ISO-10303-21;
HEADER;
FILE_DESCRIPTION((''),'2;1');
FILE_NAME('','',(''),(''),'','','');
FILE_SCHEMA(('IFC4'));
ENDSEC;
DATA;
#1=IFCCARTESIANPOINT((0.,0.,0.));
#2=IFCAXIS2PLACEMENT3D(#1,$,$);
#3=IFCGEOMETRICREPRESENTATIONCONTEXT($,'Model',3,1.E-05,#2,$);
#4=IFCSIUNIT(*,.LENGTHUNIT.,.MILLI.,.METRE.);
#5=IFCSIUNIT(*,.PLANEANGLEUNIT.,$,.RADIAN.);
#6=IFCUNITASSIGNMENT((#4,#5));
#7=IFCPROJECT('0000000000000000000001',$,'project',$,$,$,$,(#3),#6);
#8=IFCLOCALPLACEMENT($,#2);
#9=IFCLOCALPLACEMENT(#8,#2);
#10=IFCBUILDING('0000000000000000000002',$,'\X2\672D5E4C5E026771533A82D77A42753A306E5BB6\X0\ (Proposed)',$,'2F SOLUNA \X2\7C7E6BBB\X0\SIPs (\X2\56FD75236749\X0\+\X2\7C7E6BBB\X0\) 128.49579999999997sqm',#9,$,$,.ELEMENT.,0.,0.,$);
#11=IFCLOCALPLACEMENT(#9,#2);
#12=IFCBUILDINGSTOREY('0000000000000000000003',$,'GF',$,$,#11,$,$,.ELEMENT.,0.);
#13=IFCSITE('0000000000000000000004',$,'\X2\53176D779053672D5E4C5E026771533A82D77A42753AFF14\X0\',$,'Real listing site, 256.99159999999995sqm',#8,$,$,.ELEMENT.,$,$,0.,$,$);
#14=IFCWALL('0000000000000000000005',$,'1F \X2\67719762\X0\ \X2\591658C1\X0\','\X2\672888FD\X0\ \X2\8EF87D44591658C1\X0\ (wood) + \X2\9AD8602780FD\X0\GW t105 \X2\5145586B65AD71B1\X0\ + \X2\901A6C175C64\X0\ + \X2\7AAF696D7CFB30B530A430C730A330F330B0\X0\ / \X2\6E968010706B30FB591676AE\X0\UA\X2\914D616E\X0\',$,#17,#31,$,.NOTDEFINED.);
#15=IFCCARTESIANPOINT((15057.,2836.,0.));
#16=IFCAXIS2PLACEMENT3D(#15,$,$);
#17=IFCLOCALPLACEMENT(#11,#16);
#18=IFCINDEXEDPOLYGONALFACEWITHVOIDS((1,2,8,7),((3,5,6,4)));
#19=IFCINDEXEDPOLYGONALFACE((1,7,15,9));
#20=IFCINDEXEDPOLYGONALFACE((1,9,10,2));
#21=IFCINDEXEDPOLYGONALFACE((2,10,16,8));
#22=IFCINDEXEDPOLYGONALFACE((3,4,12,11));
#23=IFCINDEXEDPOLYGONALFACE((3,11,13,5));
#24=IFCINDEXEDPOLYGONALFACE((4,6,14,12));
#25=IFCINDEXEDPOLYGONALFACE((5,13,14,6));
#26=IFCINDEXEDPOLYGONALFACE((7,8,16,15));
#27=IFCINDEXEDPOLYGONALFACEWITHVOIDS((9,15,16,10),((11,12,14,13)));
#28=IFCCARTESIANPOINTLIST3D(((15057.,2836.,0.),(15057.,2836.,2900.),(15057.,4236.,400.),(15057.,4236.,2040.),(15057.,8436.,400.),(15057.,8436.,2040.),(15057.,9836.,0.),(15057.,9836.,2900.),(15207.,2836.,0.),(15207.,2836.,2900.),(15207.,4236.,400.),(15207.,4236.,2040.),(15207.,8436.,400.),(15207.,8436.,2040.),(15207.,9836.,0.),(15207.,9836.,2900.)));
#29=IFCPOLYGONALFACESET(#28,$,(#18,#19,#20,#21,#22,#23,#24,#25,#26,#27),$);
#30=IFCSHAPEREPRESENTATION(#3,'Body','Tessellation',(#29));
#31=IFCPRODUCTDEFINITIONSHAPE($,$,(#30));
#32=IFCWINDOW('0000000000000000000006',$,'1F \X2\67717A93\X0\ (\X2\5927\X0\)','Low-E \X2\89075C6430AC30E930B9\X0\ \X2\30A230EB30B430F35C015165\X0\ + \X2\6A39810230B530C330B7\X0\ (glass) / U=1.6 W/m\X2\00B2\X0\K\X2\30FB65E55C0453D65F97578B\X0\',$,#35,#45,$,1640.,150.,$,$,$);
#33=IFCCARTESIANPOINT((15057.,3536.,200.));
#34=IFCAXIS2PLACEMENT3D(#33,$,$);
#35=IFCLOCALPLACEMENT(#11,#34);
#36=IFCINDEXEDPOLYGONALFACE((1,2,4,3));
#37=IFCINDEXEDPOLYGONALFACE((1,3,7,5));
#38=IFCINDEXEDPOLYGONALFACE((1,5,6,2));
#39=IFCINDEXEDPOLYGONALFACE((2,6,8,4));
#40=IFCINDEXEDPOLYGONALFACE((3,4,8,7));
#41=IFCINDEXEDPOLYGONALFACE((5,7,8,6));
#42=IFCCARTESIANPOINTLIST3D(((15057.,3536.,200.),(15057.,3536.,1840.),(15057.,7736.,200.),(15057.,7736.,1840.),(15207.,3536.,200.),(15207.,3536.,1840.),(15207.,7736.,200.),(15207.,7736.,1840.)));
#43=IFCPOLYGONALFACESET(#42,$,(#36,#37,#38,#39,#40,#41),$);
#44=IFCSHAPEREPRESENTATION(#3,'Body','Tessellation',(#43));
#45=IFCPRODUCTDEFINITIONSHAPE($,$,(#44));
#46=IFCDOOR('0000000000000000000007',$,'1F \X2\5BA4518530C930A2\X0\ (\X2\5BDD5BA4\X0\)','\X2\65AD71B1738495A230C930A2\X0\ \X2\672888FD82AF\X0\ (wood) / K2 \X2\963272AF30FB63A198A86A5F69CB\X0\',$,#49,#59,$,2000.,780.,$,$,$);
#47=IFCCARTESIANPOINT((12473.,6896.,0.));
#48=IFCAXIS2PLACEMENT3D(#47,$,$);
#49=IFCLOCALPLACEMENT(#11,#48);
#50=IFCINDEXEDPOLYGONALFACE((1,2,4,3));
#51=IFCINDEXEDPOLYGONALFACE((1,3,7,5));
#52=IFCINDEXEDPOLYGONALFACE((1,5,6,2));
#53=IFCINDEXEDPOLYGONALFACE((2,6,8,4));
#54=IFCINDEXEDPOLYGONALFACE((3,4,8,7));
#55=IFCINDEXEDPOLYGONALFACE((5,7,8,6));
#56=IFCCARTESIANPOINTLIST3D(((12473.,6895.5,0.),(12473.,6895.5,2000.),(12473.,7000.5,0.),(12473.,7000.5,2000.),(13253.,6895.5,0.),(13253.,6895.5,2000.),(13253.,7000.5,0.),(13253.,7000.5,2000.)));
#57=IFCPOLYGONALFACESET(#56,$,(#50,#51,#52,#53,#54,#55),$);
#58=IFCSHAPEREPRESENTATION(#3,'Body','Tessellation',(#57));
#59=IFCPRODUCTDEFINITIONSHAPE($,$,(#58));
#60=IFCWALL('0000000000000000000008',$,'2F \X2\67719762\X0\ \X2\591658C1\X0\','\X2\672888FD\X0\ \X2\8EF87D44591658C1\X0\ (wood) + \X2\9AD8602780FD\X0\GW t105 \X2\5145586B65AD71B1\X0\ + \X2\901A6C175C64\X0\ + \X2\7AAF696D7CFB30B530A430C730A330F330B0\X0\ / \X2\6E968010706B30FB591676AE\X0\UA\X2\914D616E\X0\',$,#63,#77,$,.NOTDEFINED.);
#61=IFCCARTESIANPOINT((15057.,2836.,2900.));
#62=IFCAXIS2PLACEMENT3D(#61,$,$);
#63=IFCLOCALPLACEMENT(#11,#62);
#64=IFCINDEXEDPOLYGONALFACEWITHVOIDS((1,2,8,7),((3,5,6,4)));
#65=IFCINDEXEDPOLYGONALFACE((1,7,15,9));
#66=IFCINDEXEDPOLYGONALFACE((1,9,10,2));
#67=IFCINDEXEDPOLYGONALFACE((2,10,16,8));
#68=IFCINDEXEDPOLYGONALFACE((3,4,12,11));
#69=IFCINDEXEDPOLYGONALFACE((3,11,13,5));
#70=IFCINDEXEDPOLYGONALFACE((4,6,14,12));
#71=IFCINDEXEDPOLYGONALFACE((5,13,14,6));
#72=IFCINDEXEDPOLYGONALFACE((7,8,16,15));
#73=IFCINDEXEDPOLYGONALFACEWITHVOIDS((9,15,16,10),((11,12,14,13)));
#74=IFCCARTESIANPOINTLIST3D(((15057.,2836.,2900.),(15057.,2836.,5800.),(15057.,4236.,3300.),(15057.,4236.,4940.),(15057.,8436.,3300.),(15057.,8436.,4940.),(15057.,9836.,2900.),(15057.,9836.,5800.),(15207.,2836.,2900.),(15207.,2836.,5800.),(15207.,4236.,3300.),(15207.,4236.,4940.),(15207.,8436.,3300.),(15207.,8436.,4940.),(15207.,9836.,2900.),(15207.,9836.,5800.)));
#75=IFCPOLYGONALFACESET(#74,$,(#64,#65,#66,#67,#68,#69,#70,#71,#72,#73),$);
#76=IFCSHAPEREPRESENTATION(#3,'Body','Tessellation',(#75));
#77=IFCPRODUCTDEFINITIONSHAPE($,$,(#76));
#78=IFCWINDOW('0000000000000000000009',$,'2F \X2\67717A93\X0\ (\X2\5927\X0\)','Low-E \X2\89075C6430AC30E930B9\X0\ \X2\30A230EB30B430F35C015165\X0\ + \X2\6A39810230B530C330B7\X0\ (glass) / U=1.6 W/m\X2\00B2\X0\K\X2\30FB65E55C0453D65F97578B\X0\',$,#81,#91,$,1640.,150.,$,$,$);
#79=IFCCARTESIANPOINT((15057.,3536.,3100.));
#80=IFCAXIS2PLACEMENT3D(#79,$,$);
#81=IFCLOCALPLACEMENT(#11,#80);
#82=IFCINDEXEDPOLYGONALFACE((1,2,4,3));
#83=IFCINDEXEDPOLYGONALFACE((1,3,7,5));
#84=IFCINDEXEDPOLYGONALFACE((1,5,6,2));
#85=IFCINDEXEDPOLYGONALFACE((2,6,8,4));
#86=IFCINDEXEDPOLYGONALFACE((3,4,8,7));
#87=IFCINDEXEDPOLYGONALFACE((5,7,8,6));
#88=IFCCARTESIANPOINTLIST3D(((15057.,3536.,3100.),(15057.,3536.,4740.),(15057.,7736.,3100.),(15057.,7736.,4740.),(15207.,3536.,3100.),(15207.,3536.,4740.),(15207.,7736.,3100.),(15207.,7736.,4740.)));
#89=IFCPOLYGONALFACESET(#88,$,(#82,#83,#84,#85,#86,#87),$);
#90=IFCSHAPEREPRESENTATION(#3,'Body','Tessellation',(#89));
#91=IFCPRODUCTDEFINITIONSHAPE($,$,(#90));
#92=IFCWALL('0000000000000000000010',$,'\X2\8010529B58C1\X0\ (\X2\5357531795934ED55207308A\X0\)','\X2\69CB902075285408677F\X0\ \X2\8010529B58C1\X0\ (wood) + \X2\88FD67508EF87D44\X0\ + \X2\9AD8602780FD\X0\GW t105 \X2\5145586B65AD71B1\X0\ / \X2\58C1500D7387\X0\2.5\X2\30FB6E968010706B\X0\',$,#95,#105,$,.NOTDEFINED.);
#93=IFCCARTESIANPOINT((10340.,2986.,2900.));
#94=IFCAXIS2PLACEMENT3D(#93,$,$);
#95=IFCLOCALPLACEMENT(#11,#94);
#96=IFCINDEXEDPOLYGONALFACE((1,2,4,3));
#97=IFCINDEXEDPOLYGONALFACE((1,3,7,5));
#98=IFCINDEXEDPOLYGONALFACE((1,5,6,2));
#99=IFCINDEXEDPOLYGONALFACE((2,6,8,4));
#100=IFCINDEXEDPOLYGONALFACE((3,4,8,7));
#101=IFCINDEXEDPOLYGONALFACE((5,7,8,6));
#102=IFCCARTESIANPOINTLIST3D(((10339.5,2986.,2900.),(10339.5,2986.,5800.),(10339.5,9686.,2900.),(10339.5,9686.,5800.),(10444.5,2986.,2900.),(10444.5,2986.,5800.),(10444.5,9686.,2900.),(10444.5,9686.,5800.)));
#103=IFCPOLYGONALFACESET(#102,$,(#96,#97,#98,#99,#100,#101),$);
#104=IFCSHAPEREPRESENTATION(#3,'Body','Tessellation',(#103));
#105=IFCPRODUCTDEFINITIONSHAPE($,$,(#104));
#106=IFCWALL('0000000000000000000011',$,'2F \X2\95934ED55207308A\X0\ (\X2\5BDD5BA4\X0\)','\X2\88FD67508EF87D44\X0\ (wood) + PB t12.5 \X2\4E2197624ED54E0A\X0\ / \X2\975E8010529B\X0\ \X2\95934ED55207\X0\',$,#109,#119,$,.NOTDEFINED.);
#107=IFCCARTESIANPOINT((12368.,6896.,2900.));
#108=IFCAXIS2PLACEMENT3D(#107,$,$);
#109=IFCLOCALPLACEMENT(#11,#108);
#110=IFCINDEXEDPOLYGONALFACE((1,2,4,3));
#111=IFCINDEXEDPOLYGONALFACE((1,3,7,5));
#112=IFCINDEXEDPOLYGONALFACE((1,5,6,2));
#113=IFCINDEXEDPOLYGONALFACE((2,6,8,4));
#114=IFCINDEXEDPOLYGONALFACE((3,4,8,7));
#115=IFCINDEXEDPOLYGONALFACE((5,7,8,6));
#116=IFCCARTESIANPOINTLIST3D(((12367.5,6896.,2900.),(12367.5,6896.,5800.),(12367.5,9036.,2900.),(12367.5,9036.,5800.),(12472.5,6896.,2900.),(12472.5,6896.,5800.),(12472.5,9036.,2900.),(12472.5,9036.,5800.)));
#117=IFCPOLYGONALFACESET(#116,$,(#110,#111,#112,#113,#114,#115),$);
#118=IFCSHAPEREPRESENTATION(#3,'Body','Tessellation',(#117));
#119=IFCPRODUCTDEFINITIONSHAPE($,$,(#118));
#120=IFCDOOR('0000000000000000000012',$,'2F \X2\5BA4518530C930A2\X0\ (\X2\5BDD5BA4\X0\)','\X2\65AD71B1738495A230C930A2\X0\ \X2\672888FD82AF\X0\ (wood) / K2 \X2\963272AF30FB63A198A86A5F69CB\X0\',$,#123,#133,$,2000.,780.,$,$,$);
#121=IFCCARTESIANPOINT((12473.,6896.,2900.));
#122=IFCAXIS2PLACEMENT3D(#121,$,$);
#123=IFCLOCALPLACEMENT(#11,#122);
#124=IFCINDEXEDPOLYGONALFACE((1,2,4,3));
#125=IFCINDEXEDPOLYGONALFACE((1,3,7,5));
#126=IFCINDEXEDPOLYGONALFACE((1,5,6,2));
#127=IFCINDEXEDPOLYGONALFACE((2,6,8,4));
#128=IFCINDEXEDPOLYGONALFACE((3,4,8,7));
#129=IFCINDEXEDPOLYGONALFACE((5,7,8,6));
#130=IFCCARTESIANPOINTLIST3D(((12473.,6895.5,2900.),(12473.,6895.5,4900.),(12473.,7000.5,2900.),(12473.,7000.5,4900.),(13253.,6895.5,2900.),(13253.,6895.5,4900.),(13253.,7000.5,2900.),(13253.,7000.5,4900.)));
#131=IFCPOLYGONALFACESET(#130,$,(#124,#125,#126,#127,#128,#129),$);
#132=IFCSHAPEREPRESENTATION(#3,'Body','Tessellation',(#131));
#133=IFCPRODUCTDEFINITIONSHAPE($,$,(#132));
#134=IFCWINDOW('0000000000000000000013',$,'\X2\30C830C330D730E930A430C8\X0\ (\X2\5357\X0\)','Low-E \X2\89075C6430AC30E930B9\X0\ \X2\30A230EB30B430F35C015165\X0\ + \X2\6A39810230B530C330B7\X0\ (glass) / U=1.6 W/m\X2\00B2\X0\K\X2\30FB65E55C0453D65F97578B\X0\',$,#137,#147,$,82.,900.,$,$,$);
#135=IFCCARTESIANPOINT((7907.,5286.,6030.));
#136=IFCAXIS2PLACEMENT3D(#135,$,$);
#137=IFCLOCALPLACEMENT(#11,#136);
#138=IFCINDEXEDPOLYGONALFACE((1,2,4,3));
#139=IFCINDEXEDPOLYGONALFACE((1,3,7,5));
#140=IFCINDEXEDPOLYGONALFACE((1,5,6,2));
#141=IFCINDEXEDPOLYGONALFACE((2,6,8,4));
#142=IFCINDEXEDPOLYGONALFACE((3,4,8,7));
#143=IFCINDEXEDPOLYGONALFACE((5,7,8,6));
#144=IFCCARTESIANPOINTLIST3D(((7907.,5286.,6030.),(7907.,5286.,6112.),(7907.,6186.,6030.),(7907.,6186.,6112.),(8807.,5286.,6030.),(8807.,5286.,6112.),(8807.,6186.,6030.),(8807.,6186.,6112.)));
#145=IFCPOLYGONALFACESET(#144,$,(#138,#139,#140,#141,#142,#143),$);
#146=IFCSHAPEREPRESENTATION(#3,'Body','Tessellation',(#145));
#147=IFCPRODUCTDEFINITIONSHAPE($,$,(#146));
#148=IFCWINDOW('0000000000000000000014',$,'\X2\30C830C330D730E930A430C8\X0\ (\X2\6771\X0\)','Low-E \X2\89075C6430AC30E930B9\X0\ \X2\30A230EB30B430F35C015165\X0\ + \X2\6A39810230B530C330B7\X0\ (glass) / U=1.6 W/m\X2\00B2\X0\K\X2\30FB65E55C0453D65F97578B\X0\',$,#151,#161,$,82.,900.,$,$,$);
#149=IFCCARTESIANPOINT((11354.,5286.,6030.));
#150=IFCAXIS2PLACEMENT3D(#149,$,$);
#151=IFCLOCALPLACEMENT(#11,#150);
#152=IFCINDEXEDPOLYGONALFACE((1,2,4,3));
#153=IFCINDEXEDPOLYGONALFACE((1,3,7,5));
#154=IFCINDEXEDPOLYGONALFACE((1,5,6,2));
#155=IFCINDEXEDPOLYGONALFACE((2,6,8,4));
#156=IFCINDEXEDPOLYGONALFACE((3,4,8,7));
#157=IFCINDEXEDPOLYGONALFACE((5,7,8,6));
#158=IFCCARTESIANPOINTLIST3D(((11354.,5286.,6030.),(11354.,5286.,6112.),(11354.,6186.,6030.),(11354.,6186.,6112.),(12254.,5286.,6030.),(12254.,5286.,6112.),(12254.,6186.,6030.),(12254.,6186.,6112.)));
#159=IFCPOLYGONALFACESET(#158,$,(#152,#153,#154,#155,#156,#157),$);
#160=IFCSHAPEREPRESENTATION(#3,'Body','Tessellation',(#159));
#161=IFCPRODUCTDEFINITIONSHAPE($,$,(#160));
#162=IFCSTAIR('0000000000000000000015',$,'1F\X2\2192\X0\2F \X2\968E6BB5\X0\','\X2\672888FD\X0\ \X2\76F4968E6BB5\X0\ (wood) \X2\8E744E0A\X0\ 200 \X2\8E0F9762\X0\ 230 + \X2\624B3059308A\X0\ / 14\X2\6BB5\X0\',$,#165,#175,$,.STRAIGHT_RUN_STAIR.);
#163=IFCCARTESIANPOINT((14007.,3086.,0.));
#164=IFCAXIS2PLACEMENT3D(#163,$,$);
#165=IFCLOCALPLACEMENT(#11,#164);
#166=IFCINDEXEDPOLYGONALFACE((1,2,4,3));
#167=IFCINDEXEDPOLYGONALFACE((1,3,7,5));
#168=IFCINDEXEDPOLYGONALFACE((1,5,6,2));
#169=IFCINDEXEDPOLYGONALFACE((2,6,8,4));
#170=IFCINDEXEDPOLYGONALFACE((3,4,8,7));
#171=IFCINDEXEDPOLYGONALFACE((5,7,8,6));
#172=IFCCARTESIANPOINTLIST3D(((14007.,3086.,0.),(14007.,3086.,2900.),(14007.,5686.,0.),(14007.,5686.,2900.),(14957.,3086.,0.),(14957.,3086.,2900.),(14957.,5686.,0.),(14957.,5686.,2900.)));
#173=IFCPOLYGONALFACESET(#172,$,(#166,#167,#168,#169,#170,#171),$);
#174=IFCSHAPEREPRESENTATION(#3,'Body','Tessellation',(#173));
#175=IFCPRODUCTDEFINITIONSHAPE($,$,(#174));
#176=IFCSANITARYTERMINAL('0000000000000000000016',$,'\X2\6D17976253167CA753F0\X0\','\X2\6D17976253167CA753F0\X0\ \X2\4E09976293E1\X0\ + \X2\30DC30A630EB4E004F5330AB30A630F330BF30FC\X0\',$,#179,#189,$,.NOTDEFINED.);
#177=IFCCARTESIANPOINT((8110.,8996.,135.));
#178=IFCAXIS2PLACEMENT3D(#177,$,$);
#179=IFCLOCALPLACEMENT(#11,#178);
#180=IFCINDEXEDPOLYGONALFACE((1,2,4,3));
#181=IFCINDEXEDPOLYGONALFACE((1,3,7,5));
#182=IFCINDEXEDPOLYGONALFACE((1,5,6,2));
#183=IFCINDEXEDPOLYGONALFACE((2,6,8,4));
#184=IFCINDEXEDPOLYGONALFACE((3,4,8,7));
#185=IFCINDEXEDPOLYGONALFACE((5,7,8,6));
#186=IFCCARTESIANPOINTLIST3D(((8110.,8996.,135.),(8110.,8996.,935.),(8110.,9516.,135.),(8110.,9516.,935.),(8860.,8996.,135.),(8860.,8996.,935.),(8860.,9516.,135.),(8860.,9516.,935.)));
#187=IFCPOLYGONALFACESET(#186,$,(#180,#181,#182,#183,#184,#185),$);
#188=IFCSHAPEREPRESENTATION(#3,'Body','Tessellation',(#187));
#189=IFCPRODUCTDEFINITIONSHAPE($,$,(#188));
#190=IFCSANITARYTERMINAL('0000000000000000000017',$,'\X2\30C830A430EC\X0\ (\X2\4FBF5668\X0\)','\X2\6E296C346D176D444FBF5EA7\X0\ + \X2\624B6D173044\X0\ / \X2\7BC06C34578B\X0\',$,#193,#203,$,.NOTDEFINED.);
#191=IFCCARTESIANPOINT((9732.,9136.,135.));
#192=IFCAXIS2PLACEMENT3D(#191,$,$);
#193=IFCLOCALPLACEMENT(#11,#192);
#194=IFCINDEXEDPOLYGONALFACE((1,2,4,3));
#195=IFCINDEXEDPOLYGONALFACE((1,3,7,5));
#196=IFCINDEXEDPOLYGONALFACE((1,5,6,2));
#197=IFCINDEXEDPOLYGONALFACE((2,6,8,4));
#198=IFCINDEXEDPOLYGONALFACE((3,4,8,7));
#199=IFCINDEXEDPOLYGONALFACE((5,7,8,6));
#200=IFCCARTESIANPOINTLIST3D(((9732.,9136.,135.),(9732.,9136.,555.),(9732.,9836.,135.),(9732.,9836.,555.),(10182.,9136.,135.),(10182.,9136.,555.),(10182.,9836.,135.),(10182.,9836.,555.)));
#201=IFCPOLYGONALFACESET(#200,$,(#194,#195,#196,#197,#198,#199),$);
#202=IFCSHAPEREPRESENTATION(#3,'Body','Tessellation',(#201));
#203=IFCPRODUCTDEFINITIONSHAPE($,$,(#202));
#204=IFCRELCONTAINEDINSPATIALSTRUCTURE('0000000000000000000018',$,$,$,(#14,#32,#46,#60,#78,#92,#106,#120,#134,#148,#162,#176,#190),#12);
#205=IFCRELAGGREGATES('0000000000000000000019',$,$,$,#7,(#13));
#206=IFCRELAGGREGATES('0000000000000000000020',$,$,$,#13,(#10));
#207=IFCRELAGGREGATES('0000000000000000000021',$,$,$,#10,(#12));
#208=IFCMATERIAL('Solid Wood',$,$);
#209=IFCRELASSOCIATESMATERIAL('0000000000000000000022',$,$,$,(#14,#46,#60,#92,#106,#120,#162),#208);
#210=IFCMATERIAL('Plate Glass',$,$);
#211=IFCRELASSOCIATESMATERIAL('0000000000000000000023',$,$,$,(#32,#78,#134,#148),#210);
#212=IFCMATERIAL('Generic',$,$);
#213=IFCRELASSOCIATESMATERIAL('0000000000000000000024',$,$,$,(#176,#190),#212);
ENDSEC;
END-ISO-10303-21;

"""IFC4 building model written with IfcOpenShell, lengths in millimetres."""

from ifc_helpers import new_model, si_unit, frame, frame_2d, origin, place, context, project, spatial, rectangle, extrude, material, element, fill, save


model = new_model("IFC4")

# Units and contexts
model_context = context("Model", 3, precision=1e-05, world=origin())
ifc_project = project(units=[si_unit("LENGTHUNIT", "METRE", prefix="MILLI"), si_unit("PLANEANGLEUNIT", "RADIAN")], contexts=[model_context])

# Site, building, storey
site_placement = place(None, origin())
site = spatial("IfcSite", under=ifc_project, at=site_placement, Name="北海道札幌市東区苗穂町４", ObjectType="Real listing site, 256.99159999999995sqm", CompositionType="ELEMENT", RefElevation=0.0)
building_placement = place(site_placement, origin())
building = spatial("IfcBuilding", under=site, at=building_placement, Name="札幌市東区苗穂町の家 (Proposed)", ObjectType="2F SOLUNA 籾殻SIPs (国産杉+籾殻) 128.49579999999997sqm", CompositionType="ELEMENT", ElevationOfRefHeight=0.0, ElevationOfTerrain=0.0)
storey_placement = place(building_placement, origin())
storey = spatial("IfcBuildingStorey", under=building, at=storey_placement, Name="GF", CompositionType="ELEMENT", Elevation=0.0)

# Wall, opening, window
ifc_material_1 = material(Name="Solid Wood")
wall_1_placement = place(storey_placement, frame((15057.0, 2836.0, 0.0)))
wall_1 = element("IfcWall", 1, at=wall_1_placement, inside=storey, material=ifc_material_1, Name="1F 東面 外壁", Description="木製 軸組外壁 (wood) + 高性能GW t105 充填断熱 + 通気層 + 窯業系サイディング / 準耐火・外皮UA配慮", PredefinedType="NOTDEFINED", context=model_context, shape_type="SweptSolid", body=[
    extrude(rectangle(XDim=150.0, YDim=7000.0, at=frame_2d((75.0, 3500.0))), frame((15057.0, 2836.0, 0.0)), (0.0, 0.0, 1.0), 2900.0),
])
opening_1_placement = place(storey_placement, frame((15057.0, 3536.0, 200.0)))
opening_1 = element("IfcOpeningElement", 2, at=opening_1_placement, cuts=wall_1, PredefinedType="NOTDEFINED", context=model_context, shape_type="SweptSolid", body=[
    extrude(rectangle(XDim=150.0, YDim=4200.0, at=frame_2d((75.0, 2100.0))), frame((15057.0, 3536.0, 200.0)), (0.0, 0.0, 1.0), 1640.0),
])
ifc_material_2 = material(Name="Plate Glass")
window_1_placement = place(storey_placement, frame((15057.0, 3536.0, 200.0)))
window_1 = element("IfcWindow", 3, at=window_1_placement, inside=storey, material=ifc_material_2, Name="1F 東窓 (大)", Description="Low-E 複層ガラス アルゴン封入 + 樹脂サッシ (glass) / U=1.6 W/m²K・日射取得型", OverallHeight=1640.0, OverallWidth=150.0, context=model_context, shape_type="SweptSolid", body=[
    extrude(rectangle(XDim=150.0, YDim=4200.0, at=frame_2d((75.0, 2100.0))), frame((15057.0, 3536.0, 200.0)), (0.0, 0.0, 1.0), 1640.0),
])
fill(opening_1, window_1)

# Door
door_1_placement = place(storey_placement, frame((12473.0, 6896.0, 0.0)))
element("IfcDoor", 4, at=door_1_placement, inside=storey, material=ifc_material_1, Name="1F 室内ドア (寝室)", Description="断熱玄関ドア 木製芯 (wood) / K2 防犯・採風機構", OverallHeight=2000.0, OverallWidth=780.0, context=model_context, shape_type="SweptSolid", body=[
    extrude(rectangle(XDim=780.0, YDim=105.0, at=frame_2d((390.0, 52.0))), frame((12473.0, 6896.0, 0.0)), (0.0, 0.0, 1.0), 2000.0),
])

# Wall, opening, window
wall_2_placement = place(storey_placement, frame((15057.0, 2836.0, 2900.0)))
wall_2 = element("IfcWall", 5, at=wall_2_placement, inside=storey, material=ifc_material_1, Name="2F 東面 外壁", Description="木製 軸組外壁 (wood) + 高性能GW t105 充填断熱 + 通気層 + 窯業系サイディング / 準耐火・外皮UA配慮", PredefinedType="NOTDEFINED", context=model_context, shape_type="SweptSolid", body=[
    extrude(rectangle(XDim=150.0, YDim=7000.0, at=frame_2d((75.0, 3500.0))), frame((15057.0, 2836.0, 2900.0)), (0.0, 0.0, 1.0), 2900.0),
])
opening_2_placement = place(storey_placement, frame((15057.0, 3536.0, 3100.0)))
opening_2 = element("IfcOpeningElement", 6, at=opening_2_placement, cuts=wall_2, PredefinedType="NOTDEFINED", context=model_context, shape_type="SweptSolid", body=[
    extrude(rectangle(XDim=150.0, YDim=4200.0, at=frame_2d((75.0, 2100.0))), frame((15057.0, 3536.0, 3100.0)), (0.0, 0.0, 1.0), 1640.0),
])
window_2_placement = place(storey_placement, frame((15057.0, 3536.0, 3100.0)))
window_2 = element("IfcWindow", 7, at=window_2_placement, inside=storey, material=ifc_material_2, Name="2F 東窓 (大)", Description="Low-E 複層ガラス アルゴン封入 + 樹脂サッシ (glass) / U=1.6 W/m²K・日射取得型", OverallHeight=1640.0, OverallWidth=150.0, context=model_context, shape_type="SweptSolid", body=[
    extrude(rectangle(XDim=150.0, YDim=4200.0, at=frame_2d((75.0, 2100.0))), frame((15057.0, 3536.0, 3100.0)), (0.0, 0.0, 1.0), 1640.0),
])
fill(opening_2, window_2)

# Walls
wall_3_placement = place(storey_placement, frame((10340.0, 2986.0, 2900.0)))
element("IfcWall", 8, at=wall_3_placement, inside=storey, material=ifc_material_1, Name="耐力壁 (南北間仕切り)", Description="構造用合板 耐力壁 (wood) + 製材軸組 + 高性能GW t105 充填断熱 / 壁倍率2.5・準耐火", PredefinedType="NOTDEFINED", context=model_context, shape_type="SweptSolid", body=[
    extrude(rectangle(XDim=105.0, YDim=6700.0, at=frame_2d((52.0, 3350.0))), frame((10340.0, 2986.0, 2900.0)), (0.0, 0.0, 1.0), 2900.0),
])
wall_4_placement = place(storey_placement, frame((12368.0, 6896.0, 2900.0)))
element("IfcWall", 9, at=wall_4_placement, inside=storey, material=ifc_material_1, Name="2F 間仕切り (寝室)", Description="製材軸組 (wood) + PB t12.5 両面仕上 / 非耐力 間仕切", PredefinedType="NOTDEFINED", context=model_context, shape_type="SweptSolid", body=[
    extrude(rectangle(XDim=105.0, YDim=2140.0, at=frame_2d((52.0, 1070.0))), frame((12368.0, 6896.0, 2900.0)), (0.0, 0.0, 1.0), 2900.0),
])

# Door
door_2_placement = place(storey_placement, frame((12473.0, 6896.0, 2900.0)))
element("IfcDoor", 10, at=door_2_placement, inside=storey, material=ifc_material_1, Name="2F 室内ドア (寝室)", Description="断熱玄関ドア 木製芯 (wood) / K2 防犯・採風機構", OverallHeight=2000.0, OverallWidth=780.0, context=model_context, shape_type="SweptSolid", body=[
    extrude(rectangle(XDim=780.0, YDim=105.0, at=frame_2d((390.0, 52.0))), frame((12473.0, 6896.0, 2900.0)), (0.0, 0.0, 1.0), 2000.0),
])

# Windows
window_3_placement = place(storey_placement, frame((7907.0, 5286.0, 6030.0)))
element("IfcWindow", 11, at=window_3_placement, inside=storey, material=ifc_material_2, Name="トップライト (南)", Description="Low-E 複層ガラス アルゴン封入 + 樹脂サッシ (glass) / U=1.6 W/m²K・日射取得型", OverallHeight=82.0, OverallWidth=900.0, context=model_context, shape_type="SweptSolid", body=[
    extrude(rectangle(XDim=900.0, YDim=900.0, at=frame_2d((450.0, 450.0))), frame((7907.0, 5286.0, 6030.0)), (0.0, 0.0, 1.0), 82.0),
])
window_4_placement = place(storey_placement, frame((11354.0, 5286.0, 6030.0)))
element("IfcWindow", 12, at=window_4_placement, inside=storey, material=ifc_material_2, Name="トップライト (東)", Description="Low-E 複層ガラス アルゴン封入 + 樹脂サッシ (glass) / U=1.6 W/m²K・日射取得型", OverallHeight=82.0, OverallWidth=900.0, context=model_context, shape_type="SweptSolid", body=[
    extrude(rectangle(XDim=900.0, YDim=900.0, at=frame_2d((450.0, 450.0))), frame((11354.0, 5286.0, 6030.0)), (0.0, 0.0, 1.0), 82.0),
])

# Stair
stair_placement = place(storey_placement, frame((14007.0, 3086.0, 0.0)))
element("IfcStair", 13, at=stair_placement, inside=storey, material=ifc_material_1, Name="1F→2F 階段", Description="木製 直階段 (wood) 蹴上 200 踏面 230 + 手すり / 14段", PredefinedType="STRAIGHT_RUN_STAIR", context=model_context, shape_type="SweptSolid", body=[
    extrude(rectangle(XDim=950.0, YDim=2600.0, at=frame_2d((475.0, 1300.0))), frame((14007.0, 3086.0, 0.0)), (0.0, 0.0, 1.0), 2900.0),
])

# Sanitary terminals
ifc_material_3 = material(Name="Generic")
sanitary_terminal_1_placement = place(storey_placement, frame((8110.0, 8996.0, 135.0)))
element("IfcSanitaryTerminal", 14, at=sanitary_terminal_1_placement, inside=storey, material=ifc_material_3, Name="洗面化粧台", Description="洗面化粧台 三面鏡 + ボウル一体カウンター", PredefinedType="NOTDEFINED", context=model_context, shape_type="SweptSolid", body=[
    extrude(rectangle(XDim=750.0, YDim=520.0, at=frame_2d((375.0, 260.0))), frame((8110.0, 8996.0, 135.0)), (0.0, 0.0, 1.0), 800.0),
])
sanitary_terminal_2_placement = place(storey_placement, frame((9732.0, 9136.0, 135.0)))
element("IfcSanitaryTerminal", 15, at=sanitary_terminal_2_placement, inside=storey, material=ifc_material_3, Name="トイレ (便器)", Description="温水洗浄便座 + 手洗い / 節水型", PredefinedType="NOTDEFINED", context=model_context, shape_type="SweptSolid", body=[
    extrude(rectangle(XDim=450.0, YDim=700.0, at=frame_2d((225.0, 350.0))), frame((9732.0, 9136.0, 135.0)), (0.0, 0.0, 1.0), 420.0),
])

save(model, "model.ifc")
